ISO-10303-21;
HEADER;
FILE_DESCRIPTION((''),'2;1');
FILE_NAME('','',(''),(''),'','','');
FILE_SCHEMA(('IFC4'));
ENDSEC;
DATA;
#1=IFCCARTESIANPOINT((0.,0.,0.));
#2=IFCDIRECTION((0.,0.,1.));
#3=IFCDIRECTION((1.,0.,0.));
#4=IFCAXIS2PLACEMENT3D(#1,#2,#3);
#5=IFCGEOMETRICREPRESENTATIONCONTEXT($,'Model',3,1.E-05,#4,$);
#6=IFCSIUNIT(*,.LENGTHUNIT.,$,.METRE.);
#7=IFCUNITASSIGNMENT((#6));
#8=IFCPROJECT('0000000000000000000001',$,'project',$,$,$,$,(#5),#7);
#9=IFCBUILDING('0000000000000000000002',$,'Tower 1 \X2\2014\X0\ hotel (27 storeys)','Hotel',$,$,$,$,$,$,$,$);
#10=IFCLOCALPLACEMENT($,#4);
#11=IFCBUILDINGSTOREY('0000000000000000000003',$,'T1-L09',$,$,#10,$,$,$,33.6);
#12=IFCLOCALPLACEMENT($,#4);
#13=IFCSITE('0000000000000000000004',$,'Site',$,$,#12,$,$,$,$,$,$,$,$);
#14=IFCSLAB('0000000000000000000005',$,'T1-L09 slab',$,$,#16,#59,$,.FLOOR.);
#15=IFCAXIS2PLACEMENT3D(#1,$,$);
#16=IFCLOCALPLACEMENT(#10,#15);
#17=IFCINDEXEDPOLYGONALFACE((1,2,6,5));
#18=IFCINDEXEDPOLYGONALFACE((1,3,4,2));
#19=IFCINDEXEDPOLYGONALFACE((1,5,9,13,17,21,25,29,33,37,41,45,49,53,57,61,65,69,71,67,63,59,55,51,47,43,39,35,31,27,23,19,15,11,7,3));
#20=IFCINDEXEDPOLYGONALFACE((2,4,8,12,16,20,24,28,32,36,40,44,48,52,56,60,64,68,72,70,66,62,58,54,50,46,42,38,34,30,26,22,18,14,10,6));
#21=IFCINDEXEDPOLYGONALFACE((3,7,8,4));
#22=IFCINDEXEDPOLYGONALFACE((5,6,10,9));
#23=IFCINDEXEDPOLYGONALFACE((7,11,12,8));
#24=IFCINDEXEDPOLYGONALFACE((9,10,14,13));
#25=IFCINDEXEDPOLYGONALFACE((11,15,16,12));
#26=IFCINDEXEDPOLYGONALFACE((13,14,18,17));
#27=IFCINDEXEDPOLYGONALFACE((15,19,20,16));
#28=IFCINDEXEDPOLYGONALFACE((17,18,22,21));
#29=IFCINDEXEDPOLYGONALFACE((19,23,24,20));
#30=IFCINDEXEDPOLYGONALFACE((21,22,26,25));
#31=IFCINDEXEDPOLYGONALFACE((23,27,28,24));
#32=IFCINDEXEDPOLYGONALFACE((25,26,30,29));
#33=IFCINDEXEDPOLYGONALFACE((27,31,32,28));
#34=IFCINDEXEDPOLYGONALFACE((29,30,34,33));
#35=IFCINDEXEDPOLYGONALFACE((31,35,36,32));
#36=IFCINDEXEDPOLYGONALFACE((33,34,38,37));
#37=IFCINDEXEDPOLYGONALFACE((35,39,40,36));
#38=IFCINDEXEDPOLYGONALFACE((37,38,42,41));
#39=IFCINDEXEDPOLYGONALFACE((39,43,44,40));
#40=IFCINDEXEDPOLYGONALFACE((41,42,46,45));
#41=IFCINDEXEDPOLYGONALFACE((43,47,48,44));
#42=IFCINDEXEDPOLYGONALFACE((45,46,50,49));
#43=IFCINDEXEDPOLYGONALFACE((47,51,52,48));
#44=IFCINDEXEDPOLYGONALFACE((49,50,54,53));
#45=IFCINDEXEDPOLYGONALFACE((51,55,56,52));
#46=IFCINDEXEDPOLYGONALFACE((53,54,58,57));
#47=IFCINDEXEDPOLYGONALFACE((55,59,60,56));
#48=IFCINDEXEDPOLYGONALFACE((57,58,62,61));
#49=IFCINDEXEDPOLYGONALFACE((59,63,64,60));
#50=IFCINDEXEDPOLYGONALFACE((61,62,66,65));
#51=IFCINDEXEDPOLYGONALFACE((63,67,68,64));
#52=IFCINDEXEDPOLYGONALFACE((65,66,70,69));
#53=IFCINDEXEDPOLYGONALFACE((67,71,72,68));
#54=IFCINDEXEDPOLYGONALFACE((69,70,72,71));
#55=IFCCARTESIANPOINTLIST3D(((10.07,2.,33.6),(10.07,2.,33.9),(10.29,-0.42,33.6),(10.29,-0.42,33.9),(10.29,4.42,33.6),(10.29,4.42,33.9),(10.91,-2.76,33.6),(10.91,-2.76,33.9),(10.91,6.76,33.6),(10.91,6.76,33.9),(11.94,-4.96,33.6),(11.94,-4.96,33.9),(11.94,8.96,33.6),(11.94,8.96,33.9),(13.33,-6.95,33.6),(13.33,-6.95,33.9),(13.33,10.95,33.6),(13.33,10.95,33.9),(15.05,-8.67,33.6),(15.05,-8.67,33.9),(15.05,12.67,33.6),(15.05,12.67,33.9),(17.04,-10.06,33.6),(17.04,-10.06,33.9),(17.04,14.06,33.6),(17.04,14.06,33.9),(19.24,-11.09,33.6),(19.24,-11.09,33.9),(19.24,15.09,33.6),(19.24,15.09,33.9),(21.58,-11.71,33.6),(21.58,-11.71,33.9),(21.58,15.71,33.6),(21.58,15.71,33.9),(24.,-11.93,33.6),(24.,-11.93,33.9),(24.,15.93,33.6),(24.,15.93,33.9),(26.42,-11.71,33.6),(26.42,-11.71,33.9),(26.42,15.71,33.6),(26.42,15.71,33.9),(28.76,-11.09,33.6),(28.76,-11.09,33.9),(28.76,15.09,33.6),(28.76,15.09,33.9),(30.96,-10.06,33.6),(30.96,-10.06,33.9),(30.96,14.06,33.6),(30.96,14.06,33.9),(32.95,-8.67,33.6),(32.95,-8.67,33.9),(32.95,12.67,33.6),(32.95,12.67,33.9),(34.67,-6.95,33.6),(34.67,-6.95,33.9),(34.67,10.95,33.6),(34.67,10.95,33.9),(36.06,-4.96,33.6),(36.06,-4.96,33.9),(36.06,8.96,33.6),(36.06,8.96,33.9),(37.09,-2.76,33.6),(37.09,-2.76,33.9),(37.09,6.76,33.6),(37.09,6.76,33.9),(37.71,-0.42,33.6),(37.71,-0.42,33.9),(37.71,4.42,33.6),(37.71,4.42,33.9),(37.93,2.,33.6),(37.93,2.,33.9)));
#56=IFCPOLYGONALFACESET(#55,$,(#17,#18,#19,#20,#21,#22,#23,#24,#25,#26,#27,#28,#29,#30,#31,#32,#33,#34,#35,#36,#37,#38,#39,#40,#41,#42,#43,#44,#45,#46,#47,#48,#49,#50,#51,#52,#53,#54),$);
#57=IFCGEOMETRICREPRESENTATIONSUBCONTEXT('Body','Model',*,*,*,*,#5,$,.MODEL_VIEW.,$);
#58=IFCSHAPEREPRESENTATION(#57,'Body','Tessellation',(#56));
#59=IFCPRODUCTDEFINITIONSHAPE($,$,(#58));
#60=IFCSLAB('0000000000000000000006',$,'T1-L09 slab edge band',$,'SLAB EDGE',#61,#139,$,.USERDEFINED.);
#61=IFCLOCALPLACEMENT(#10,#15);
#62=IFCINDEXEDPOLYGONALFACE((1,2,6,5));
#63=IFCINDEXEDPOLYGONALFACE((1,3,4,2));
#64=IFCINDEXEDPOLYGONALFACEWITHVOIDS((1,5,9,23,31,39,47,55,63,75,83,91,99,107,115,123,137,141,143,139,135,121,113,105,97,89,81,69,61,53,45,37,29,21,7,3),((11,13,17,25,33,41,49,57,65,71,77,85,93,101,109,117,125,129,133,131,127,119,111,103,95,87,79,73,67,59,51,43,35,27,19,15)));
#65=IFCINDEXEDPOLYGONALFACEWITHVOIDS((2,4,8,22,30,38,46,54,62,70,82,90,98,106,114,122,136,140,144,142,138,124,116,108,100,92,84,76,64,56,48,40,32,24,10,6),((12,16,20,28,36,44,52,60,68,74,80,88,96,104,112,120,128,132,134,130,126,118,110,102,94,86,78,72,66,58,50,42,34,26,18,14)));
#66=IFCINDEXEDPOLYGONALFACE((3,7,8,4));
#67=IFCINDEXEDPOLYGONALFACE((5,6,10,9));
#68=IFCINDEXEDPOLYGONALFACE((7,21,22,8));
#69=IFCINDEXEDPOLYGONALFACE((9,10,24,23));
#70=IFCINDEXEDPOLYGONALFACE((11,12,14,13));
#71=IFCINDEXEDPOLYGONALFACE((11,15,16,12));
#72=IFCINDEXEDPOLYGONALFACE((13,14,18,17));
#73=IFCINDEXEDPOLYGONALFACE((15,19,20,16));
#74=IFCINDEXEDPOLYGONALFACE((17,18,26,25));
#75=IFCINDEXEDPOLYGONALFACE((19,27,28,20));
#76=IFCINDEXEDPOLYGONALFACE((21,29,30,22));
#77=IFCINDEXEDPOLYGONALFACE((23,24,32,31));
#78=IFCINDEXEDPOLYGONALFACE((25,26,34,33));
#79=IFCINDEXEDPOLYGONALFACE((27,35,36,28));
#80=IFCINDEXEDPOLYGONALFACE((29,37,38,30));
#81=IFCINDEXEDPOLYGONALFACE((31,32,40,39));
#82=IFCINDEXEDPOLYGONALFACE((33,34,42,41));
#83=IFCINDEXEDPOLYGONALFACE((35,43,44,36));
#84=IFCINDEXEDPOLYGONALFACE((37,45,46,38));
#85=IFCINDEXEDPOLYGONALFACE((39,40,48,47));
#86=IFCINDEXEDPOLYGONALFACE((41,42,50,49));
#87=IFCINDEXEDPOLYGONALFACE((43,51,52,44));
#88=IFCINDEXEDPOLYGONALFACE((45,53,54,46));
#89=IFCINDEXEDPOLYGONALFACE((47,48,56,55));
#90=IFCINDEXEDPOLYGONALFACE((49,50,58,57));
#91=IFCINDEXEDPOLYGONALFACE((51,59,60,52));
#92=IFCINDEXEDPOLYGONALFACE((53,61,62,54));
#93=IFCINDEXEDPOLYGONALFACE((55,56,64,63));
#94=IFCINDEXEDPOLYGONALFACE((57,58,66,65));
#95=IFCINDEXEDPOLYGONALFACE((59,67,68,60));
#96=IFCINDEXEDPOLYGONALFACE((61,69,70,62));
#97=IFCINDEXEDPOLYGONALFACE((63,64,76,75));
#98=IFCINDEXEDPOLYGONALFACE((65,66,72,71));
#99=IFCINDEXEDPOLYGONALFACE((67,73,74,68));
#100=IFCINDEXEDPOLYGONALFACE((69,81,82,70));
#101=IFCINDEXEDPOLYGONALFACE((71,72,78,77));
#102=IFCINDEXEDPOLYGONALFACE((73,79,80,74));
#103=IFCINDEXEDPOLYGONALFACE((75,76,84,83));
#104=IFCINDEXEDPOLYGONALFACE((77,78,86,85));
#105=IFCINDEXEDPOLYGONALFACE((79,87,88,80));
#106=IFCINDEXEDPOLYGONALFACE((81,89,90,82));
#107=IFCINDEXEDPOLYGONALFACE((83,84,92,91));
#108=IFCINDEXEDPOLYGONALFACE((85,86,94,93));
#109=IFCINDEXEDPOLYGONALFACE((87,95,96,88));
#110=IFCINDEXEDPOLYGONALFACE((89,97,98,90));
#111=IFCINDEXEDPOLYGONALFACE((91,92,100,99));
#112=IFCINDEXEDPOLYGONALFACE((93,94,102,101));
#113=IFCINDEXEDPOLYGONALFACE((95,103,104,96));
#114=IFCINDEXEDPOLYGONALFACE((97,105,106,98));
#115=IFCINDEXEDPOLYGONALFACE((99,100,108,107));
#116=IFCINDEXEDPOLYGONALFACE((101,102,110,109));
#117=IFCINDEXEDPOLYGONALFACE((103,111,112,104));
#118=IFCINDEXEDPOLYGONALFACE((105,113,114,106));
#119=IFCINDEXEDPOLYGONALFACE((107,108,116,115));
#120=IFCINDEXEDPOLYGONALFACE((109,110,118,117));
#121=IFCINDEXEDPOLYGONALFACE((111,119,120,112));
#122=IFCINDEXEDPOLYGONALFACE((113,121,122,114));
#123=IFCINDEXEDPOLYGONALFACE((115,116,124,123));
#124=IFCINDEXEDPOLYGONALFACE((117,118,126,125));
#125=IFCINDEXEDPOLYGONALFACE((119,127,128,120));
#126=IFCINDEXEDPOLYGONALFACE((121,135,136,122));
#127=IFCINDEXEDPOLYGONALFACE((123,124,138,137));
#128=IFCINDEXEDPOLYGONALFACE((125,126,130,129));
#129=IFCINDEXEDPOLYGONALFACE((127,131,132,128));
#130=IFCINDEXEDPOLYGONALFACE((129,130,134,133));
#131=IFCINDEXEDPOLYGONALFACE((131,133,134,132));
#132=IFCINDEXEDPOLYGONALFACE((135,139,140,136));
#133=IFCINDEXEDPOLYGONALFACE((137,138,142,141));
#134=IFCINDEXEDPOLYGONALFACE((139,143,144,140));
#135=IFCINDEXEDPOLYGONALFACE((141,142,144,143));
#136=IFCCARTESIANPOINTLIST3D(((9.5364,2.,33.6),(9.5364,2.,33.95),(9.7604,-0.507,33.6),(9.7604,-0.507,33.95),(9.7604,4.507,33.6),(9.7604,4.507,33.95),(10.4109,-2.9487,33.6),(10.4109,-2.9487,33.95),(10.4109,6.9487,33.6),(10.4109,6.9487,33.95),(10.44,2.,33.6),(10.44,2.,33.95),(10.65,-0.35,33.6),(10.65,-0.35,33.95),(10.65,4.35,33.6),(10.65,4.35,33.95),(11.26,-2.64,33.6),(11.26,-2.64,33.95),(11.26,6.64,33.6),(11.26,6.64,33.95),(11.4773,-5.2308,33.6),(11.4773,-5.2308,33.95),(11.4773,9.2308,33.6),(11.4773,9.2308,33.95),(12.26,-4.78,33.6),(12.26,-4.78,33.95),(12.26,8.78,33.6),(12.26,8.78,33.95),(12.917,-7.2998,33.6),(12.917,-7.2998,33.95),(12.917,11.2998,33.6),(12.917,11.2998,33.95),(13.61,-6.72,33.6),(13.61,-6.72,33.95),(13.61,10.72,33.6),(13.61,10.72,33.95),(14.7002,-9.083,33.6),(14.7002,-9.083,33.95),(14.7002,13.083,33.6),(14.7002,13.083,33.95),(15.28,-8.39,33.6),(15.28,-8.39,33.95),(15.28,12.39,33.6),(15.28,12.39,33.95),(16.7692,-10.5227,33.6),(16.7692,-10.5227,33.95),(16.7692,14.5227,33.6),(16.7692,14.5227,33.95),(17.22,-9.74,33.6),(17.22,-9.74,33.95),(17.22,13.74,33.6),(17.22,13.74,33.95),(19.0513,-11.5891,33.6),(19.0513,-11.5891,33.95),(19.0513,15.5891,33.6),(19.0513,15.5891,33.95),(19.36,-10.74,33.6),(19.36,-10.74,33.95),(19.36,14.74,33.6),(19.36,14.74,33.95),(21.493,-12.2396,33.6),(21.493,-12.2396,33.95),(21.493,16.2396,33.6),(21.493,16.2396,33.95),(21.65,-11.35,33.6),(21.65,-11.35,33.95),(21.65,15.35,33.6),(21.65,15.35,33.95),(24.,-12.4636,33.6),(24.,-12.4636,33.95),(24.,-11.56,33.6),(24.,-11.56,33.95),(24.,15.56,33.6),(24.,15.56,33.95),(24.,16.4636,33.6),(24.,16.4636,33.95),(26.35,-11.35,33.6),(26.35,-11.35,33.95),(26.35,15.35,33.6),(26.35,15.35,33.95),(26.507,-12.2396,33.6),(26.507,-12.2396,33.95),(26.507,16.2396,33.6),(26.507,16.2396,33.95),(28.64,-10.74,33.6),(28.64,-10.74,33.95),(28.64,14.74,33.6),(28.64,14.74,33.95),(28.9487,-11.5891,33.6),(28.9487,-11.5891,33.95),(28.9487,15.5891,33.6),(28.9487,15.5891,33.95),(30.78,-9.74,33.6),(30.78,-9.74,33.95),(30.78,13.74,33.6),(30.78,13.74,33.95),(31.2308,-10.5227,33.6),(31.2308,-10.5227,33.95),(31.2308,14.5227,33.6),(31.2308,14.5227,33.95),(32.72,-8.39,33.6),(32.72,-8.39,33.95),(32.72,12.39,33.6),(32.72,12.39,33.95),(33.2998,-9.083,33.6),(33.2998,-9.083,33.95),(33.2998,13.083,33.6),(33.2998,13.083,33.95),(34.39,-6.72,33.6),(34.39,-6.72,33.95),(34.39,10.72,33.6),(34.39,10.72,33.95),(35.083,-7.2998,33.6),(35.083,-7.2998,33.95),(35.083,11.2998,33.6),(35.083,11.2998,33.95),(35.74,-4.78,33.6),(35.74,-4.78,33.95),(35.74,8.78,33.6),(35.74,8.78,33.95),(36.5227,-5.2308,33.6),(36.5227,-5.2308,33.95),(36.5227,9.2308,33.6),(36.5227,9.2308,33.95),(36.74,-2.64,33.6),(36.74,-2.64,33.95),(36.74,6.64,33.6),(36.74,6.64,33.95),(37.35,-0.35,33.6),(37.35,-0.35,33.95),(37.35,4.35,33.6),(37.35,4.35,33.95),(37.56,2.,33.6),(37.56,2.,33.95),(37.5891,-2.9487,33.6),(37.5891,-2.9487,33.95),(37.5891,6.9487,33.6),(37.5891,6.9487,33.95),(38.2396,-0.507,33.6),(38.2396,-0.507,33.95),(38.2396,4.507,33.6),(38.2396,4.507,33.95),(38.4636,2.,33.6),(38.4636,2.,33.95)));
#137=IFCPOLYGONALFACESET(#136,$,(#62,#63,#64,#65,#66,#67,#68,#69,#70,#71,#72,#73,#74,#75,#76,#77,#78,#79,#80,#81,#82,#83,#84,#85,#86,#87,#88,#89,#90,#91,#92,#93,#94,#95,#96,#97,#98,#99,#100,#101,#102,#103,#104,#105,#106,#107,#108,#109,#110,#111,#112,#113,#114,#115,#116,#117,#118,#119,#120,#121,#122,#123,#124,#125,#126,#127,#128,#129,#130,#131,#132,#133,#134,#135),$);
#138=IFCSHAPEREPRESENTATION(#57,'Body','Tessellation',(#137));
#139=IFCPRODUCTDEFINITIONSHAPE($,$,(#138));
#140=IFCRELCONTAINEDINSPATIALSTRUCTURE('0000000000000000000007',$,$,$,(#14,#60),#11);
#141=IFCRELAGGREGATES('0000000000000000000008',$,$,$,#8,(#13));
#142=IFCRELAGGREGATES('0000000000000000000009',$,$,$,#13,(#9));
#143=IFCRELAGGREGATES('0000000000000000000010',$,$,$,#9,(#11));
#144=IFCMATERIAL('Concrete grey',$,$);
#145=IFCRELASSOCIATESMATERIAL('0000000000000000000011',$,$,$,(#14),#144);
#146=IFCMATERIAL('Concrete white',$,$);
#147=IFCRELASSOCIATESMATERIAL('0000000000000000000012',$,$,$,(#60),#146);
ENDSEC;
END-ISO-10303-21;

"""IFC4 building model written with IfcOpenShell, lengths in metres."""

from ifc_helpers import new_model, si_unit, frame, origin_with_axes, place, context, subcontext, project, spatial, polyline, outline, extrude, material, element, save


model = new_model("IFC4")

# Units and contexts
model_context = context("Model", 3, precision=1e-05, world=origin_with_axes())
body_context = subcontext(model_context, "Body", "Model", "MODEL_VIEW")
ifc_project = project(units=[si_unit("LENGTHUNIT", "METRE")], contexts=[model_context])

# Site, building, storey
site_placement = place(None, origin_with_axes())
site = spatial("IfcSite", under=ifc_project, at=site_placement, Name="Site")
building = spatial("IfcBuilding", under=site, Name="Tower 1 — hotel (27 storeys)", Description="Hotel")
storey_placement = place(None, origin_with_axes())
storey = spatial("IfcBuildingStorey", under=building, at=storey_placement, Name="T1-L09", Elevation=33.6)

# Slab
ifc_material_1 = material(Name="Concrete grey")
slab_1_placement = place(storey_placement, origin_with_axes())
element("IfcSlab", 1, at=slab_1_placement, inside=storey, material=ifc_material_1, Name="T1-L09 slab", PredefinedType="FLOOR", context=body_context, shape_type="SweptSolid", body=[
    extrude(outline(polyline([(37.71, -0.42), (37.93, 2.0), (37.71, 4.42), (37.09, 6.76), (36.06, 8.96), (34.67, 10.95), (32.95, 12.67), (30.96, 14.06), (28.76, 15.09), (26.42, 15.71), (24.0, 15.93), (21.58, 15.71), (19.24, 15.09), (17.04, 14.06), (15.05, 12.67), (13.33, 10.95), (11.94, 8.96), (10.91, 6.76), (10.29, 4.42), (10.07, 2.0), (10.29, -0.42), (10.91, -2.76), (11.94, -4.96), (13.33, -6.95), (15.05, -8.67), (17.04, -10.06), (19.24, -11.09), (21.58, -11.71), (24.0, -11.93), (26.42, -11.71), (28.76, -11.09), (30.96, -10.06), (32.95, -8.67), (34.67, -6.95), (36.06, -4.96), (37.09, -2.76), (37.71, -0.42)])), frame((0.0, 0.0, 33.6), z_axis=(0.0, 0.0, 1.0), x_axis=(1.0, 0.0, 0.0)), (0.0, 0.0, 1.0), 0.3),
])

# Slab
ifc_material_2 = material(Name="Concrete white")
slab_2_placement = place(storey_placement, origin_with_axes())
element("IfcSlab", 2, at=slab_2_placement, inside=storey, material=ifc_material_2, Name="T1-L09 slab edge band", ObjectType="SLAB EDGE", PredefinedType="USERDEFINED", context=body_context, shape_type="SweptSolid", body=[
    extrude(outline(polyline([(38.4636, 2.0), (38.2396, 4.507), (37.5891, 6.9487), (36.5227, 9.2308), (35.083, 11.2998), (33.2998, 13.083), (31.2308, 14.5227), (28.9487, 15.5891), (26.507, 16.2396), (24.0, 16.4636), (21.493, 16.2396), (19.0513, 15.5891), (16.7692, 14.5227), (14.7002, 13.083), (12.917, 11.2998), (11.4773, 9.2308), (10.4109, 6.9487), (9.7604, 4.507), (9.5364, 2.0), (9.7604, -0.507), (10.4109, -2.9487), (11.4773, -5.2308), (12.917, -7.2998), (14.7002, -9.083), (16.7692, -10.5227), (19.0513, -11.5891), (21.493, -12.2396), (24.0, -12.4636), (26.507, -12.2396), (28.9487, -11.5891), (31.2308, -10.5227), (33.2998, -9.083), (35.083, -7.2998), (36.5227, -5.2308), (37.5891, -2.9487), (38.2396, -0.507), (38.4636, 2.0)]), holes=[polyline([(37.56, 2.0), (37.35, 4.35), (36.74, 6.64), (35.74, 8.78), (34.39, 10.72), (32.72, 12.39), (30.78, 13.74), (28.64, 14.74), (26.35, 15.35), (24.0, 15.56), (21.65, 15.35), (19.36, 14.74), (17.22, 13.74), (15.28, 12.39), (13.61, 10.72), (12.26, 8.78), (11.26, 6.64), (10.65, 4.35), (10.44, 2.0), (10.65, -0.35), (11.26, -2.64), (12.26, -4.78), (13.61, -6.72), (15.28, -8.39), (17.22, -9.74), (19.36, -10.74), (21.65, -11.35), (24.0, -11.56), (26.35, -11.35), (28.64, -10.74), (30.78, -9.74), (32.72, -8.39), (34.39, -6.72), (35.74, -4.78), (36.74, -2.64), (37.35, -0.35), (37.56, 2.0)])]), frame((0.0, 0.0, 33.6), z_axis=(0.0, 0.0, 1.0), x_axis=(1.0, 0.0, 0.0)), (0.0, 0.0, 1.0), 0.35),
])

save(model, "model.ifc")
